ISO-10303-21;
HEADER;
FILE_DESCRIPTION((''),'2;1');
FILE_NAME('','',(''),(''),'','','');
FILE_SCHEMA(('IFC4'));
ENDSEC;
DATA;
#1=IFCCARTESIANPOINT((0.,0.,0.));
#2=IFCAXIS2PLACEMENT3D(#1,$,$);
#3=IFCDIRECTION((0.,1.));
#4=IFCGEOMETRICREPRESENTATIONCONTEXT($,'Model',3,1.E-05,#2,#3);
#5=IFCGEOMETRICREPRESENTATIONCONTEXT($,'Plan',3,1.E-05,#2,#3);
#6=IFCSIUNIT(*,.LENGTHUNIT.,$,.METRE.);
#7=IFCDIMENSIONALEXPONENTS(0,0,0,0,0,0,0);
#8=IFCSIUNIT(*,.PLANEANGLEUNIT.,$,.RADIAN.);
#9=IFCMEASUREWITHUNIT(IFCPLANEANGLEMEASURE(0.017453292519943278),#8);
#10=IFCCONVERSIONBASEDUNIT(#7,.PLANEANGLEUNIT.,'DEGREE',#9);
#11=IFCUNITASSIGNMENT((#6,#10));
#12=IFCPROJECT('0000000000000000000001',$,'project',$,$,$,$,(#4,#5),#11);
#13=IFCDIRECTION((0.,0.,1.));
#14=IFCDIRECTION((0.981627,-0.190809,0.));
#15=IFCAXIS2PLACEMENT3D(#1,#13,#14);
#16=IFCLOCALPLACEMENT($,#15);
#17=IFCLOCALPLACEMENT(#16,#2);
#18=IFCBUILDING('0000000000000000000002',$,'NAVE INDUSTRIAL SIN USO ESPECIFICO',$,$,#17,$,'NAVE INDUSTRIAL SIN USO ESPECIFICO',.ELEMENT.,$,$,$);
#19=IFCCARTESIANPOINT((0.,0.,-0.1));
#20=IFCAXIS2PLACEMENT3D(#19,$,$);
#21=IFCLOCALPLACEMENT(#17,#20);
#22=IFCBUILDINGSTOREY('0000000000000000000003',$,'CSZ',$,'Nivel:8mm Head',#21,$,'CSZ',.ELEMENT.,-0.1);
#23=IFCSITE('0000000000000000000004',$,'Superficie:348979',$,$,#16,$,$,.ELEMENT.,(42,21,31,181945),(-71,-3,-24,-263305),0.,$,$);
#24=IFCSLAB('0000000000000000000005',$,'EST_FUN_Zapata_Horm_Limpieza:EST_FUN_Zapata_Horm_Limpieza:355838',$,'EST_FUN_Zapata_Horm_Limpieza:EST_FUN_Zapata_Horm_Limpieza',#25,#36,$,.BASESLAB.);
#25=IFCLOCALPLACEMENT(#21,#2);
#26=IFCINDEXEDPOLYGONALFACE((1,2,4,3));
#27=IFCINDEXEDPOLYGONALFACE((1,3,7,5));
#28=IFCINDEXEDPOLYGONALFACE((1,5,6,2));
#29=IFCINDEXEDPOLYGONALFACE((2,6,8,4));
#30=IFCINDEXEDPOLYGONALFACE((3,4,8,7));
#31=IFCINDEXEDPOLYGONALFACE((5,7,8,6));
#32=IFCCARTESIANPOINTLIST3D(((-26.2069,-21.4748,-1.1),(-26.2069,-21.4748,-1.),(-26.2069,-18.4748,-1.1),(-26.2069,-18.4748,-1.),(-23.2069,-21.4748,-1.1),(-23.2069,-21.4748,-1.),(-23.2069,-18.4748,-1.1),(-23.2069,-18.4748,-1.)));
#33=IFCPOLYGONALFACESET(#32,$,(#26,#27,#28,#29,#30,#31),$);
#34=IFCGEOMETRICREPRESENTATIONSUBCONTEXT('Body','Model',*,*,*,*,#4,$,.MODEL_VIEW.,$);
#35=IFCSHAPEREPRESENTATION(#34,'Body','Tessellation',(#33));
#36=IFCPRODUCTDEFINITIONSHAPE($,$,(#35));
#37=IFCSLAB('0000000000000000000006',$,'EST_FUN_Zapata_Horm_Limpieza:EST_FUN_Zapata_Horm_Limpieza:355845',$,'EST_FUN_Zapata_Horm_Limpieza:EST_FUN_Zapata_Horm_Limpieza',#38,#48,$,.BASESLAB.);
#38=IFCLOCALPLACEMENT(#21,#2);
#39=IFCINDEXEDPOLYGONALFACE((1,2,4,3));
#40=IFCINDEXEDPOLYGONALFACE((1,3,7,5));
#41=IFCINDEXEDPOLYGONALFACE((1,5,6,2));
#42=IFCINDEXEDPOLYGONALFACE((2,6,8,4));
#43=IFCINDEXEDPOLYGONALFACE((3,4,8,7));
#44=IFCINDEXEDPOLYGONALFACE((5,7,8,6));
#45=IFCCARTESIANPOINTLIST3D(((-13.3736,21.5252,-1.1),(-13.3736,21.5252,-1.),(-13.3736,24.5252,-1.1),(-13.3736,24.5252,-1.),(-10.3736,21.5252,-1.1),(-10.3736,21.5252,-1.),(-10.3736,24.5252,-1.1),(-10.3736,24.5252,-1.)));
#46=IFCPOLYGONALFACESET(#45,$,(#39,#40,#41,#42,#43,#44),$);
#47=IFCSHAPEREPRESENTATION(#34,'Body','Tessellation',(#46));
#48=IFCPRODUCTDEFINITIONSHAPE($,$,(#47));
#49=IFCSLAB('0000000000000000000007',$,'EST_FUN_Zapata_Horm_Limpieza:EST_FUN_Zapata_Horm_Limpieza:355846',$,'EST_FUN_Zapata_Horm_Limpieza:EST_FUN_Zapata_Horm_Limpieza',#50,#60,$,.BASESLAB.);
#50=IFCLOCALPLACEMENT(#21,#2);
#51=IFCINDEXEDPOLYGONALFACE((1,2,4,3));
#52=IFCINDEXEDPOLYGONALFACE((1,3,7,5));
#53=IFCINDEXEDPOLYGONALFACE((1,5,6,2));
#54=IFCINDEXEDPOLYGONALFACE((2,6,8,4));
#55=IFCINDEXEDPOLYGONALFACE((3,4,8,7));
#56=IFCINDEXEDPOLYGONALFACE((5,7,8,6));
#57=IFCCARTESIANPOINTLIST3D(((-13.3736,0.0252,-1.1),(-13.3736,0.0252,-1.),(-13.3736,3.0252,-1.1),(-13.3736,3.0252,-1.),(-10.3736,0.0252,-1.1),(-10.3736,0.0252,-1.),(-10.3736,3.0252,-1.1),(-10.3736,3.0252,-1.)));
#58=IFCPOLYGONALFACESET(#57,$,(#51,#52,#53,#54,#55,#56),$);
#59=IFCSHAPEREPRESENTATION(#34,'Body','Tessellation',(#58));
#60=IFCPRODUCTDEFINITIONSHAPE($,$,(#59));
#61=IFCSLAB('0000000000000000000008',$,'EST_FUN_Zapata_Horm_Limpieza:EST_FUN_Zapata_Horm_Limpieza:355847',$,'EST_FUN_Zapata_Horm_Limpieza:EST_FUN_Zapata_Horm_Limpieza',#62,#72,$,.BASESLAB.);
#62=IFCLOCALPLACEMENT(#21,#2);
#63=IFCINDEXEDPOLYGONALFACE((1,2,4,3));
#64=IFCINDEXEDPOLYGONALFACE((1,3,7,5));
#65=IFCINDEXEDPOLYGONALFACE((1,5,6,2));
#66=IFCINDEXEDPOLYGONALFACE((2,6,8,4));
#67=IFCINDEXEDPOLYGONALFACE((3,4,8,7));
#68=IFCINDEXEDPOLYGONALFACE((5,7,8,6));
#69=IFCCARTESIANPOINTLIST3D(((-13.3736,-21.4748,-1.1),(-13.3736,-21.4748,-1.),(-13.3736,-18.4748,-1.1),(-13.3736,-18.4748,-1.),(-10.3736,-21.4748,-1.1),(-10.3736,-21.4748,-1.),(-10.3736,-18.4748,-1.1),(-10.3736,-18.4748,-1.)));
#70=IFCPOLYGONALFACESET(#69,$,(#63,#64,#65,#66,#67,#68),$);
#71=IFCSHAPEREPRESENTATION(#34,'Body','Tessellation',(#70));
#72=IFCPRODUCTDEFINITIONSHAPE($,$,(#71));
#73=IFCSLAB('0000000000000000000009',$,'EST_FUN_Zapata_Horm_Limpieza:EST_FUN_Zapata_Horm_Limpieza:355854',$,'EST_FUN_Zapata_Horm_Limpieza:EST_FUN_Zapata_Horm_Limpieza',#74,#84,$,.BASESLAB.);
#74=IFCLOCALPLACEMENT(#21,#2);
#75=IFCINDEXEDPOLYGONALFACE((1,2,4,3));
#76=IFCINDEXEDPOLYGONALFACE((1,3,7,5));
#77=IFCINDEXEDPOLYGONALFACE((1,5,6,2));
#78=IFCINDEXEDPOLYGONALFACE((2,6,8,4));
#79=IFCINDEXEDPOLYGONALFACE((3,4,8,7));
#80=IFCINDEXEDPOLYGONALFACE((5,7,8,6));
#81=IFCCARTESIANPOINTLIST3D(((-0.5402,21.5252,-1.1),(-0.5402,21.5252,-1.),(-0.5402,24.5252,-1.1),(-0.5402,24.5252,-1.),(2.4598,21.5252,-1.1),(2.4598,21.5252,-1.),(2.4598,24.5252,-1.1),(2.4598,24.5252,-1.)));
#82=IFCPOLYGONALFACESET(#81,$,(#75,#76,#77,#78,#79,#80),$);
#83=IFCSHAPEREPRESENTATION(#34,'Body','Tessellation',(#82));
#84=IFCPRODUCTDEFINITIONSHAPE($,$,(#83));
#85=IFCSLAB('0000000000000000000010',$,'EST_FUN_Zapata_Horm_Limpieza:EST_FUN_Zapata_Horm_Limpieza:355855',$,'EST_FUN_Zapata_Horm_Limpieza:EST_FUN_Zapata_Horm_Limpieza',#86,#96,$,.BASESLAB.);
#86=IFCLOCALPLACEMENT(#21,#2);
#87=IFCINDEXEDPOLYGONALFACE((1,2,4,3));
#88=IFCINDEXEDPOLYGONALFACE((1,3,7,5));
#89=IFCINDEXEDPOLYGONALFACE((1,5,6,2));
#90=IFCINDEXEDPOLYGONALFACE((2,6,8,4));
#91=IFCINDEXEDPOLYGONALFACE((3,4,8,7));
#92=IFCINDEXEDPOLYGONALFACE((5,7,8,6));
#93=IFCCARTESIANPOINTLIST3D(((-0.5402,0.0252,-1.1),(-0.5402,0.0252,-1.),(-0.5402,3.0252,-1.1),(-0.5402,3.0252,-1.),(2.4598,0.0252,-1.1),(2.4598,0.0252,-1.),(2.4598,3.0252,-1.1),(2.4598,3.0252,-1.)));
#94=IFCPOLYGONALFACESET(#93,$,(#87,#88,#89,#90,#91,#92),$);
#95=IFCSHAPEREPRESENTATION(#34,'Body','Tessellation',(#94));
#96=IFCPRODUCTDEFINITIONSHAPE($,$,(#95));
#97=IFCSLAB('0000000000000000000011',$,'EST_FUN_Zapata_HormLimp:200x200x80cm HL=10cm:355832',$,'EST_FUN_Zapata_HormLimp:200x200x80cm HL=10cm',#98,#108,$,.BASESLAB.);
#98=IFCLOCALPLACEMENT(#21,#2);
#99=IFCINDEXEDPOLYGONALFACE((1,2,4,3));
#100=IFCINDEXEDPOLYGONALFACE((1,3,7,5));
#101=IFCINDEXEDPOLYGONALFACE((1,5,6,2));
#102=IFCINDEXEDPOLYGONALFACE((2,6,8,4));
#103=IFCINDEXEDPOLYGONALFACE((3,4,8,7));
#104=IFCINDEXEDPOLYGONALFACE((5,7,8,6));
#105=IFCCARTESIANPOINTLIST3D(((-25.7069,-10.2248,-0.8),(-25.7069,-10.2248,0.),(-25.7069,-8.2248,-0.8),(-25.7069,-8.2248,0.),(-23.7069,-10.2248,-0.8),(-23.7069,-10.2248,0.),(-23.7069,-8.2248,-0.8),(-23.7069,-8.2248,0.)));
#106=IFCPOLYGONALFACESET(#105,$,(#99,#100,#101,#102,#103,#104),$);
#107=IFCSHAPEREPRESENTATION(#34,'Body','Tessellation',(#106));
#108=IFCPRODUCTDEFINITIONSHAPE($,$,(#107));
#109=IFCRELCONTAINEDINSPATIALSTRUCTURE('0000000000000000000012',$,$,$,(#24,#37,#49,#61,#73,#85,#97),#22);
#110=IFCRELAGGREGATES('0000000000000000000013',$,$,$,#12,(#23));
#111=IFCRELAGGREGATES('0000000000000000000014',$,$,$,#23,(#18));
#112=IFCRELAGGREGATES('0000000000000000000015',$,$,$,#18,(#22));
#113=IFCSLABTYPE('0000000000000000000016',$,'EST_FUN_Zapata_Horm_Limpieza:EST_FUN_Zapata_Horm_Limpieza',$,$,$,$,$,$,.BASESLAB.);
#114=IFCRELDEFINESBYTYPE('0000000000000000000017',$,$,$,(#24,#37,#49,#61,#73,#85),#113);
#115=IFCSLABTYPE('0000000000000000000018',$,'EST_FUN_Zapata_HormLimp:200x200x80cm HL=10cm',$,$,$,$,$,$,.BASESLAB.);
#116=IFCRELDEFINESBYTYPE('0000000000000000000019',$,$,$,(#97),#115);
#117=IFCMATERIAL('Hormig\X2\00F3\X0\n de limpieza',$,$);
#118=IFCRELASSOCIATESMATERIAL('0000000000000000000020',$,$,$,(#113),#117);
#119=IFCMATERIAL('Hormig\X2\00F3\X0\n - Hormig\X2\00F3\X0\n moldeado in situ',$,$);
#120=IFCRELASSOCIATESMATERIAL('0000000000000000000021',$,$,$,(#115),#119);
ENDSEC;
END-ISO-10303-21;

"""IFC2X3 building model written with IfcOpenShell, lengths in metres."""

from ifc_helpers import new_model, entity, si_unit, converted_unit, direction, frame, frame_2d, origin, origin_2d_with_axis, place, context, subcontext, project, spatial, rectangle, extrude, material, type_object, element, save


model = new_model("IFC2X3")

# Units and contexts
model_context = context("Model", 3, precision=1e-05, world=origin(), true_north=direction((0.0, 1.0)))
plan_context = context("Plan", 3, precision=1e-05, world=origin(), true_north=direction((0.0, 1.0)))
body_context = subcontext(model_context, "Body", "Model", "MODEL_VIEW")
ifc_project = project(units=[si_unit("LENGTHUNIT", "METRE"), converted_unit("PLANEANGLEUNIT", "DEGREE", entity("IfcPlaneAngleMeasure", 0.017453292519943278), si_unit("PLANEANGLEUNIT", "RADIAN"), dimensions=[0, 0, 0, 0, 0, 0, 0])], contexts=[model_context, plan_context])

# Site, building, storey
site_placement = place(None, frame((0.0, 0.0, 0.0), z_axis=(0.0, 0.0, 1.0), x_axis=(0.981627, -0.190809, 0.0)))
site = spatial("IfcSite", under=ifc_project, at=site_placement, Name="Superficie:348979", CompositionType="ELEMENT", RefLatitude=(42, 21, 31, 181945), RefLongitude=(-71, -3, -24, -263305), RefElevation=0.0)
building_placement = place(site_placement, origin())
building = spatial("IfcBuilding", under=site, at=building_placement, Name="NAVE INDUSTRIAL SIN USO ESPECIFICO", LongName="NAVE INDUSTRIAL SIN USO ESPECIFICO", CompositionType="ELEMENT")
storey_placement = place(building_placement, frame((0.0, 0.0, -0.1)))
storey = spatial("IfcBuildingStorey", under=building, at=storey_placement, Name="CSZ", ObjectType="Nivel:8mm Head", LongName="CSZ", CompositionType="ELEMENT", Elevation=-0.1)

# Slabs
ifc_material_1 = material(Name="Hormigón - Hormigón moldeado in situ")
ifc_material_2 = material(Name="Hormigón de limpieza")
slab_type_1 = type_object("IfcSlabType", Name="EST_FUN_Zapata_Horm_Limpieza:EST_FUN_Zapata_Horm_Limpieza", PredefinedType="BASESLAB", material=ifc_material_2)
slab_1_placement = place(storey_placement, frame((0.0, 0.0, -1.0)))
element("IfcSlab", 1, at=slab_1_placement, inside=storey, type_object=slab_type_1, Name="EST_FUN_Zapata_Horm_Limpieza:EST_FUN_Zapata_Horm_Limpieza:355838", ObjectType="EST_FUN_Zapata_Horm_Limpieza:EST_FUN_Zapata_Horm_Limpieza", PredefinedType="BASESLAB", context=body_context, shape_type="SweptSolid", body=[
    extrude(rectangle(XDim=3.0, YDim=3.0, at=frame_2d((0.0, 0.0), x_axis=(1.0, 0.0))), frame((-24.7069, -19.9748, -0.1)), (0.0, 0.0, 1.0), 0.1),
])
slab_2_placement = place(storey_placement, frame((0.0, 0.0, -1.0)))
element("IfcSlab", 2, at=slab_2_placement, inside=storey, type_object=slab_type_1, Name="EST_FUN_Zapata_Horm_Limpieza:EST_FUN_Zapata_Horm_Limpieza:355845", ObjectType="EST_FUN_Zapata_Horm_Limpieza:EST_FUN_Zapata_Horm_Limpieza", PredefinedType="BASESLAB", context=body_context, shape_type="SweptSolid", body=[
    extrude(rectangle(XDim=3.0, YDim=3.0, at=origin_2d_with_axis()), frame((-11.8736, 23.0252, -0.1)), (0.0, 0.0, 1.0), 0.1),
])
slab_3_placement = place(storey_placement, frame((0.0, 0.0, -1.0)))
element("IfcSlab", 3, at=slab_3_placement, inside=storey, type_object=slab_type_1, Name="EST_FUN_Zapata_Horm_Limpieza:EST_FUN_Zapata_Horm_Limpieza:355846", ObjectType="EST_FUN_Zapata_Horm_Limpieza:EST_FUN_Zapata_Horm_Limpieza", PredefinedType="BASESLAB", context=body_context, shape_type="SweptSolid", body=[
    extrude(rectangle(XDim=3.0, YDim=3.0, at=origin_2d_with_axis()), frame((-11.8736, 1.5252, -0.1)), (0.0, 0.0, 1.0), 0.1),
])
slab_4_placement = place(storey_placement, frame((0.0, 0.0, -1.0)))
element("IfcSlab", 4, at=slab_4_placement, inside=storey, type_object=slab_type_1, Name="EST_FUN_Zapata_Horm_Limpieza:EST_FUN_Zapata_Horm_Limpieza:355847", ObjectType="EST_FUN_Zapata_Horm_Limpieza:EST_FUN_Zapata_Horm_Limpieza", PredefinedType="BASESLAB", context=body_context, shape_type="SweptSolid", body=[
    extrude(rectangle(XDim=3.0, YDim=3.0, at=frame_2d((0.0, 0.0), x_axis=(1.0, 0.0))), frame((-11.8736, -19.9748, -0.1)), (0.0, 0.0, 1.0), 0.1),
])
slab_5_placement = place(storey_placement, frame((0.0, 0.0, -1.0)))
element("IfcSlab", 5, at=slab_5_placement, inside=storey, type_object=slab_type_1, Name="EST_FUN_Zapata_Horm_Limpieza:EST_FUN_Zapata_Horm_Limpieza:355854", ObjectType="EST_FUN_Zapata_Horm_Limpieza:EST_FUN_Zapata_Horm_Limpieza", PredefinedType="BASESLAB", context=body_context, shape_type="SweptSolid", body=[
    extrude(rectangle(XDim=3.0, YDim=3.0, at=origin_2d_with_axis()), frame((0.9598, 23.0252, -0.1)), (0.0, 0.0, 1.0), 0.1),
])
slab_6_placement = place(storey_placement, frame((0.0, 0.0, -1.0)))
element("IfcSlab", 6, at=slab_6_placement, inside=storey, type_object=slab_type_1, Name="EST_FUN_Zapata_Horm_Limpieza:EST_FUN_Zapata_Horm_Limpieza:355855", ObjectType="EST_FUN_Zapata_Horm_Limpieza:EST_FUN_Zapata_Horm_Limpieza", PredefinedType="BASESLAB", context=body_context, shape_type="SweptSolid", body=[
    extrude(rectangle(XDim=3.0, YDim=3.0, at=origin_2d_with_axis()), frame((0.9598, 1.5252, -0.1)), (0.0, 0.0, 1.0), 0.1),
])
slab_type_2 = type_object("IfcSlabType", Name="EST_FUN_Zapata_HormLimp:200x200x80cm HL=10cm", PredefinedType="BASESLAB", material=ifc_material_1)
slab_7_placement = place(storey_placement, origin())
element("IfcSlab", 7, at=slab_7_placement, inside=storey, type_object=slab_type_2, Name="EST_FUN_Zapata_HormLimp:200x200x80cm HL=10cm:355832", ObjectType="EST_FUN_Zapata_HormLimp:200x200x80cm HL=10cm", PredefinedType="BASESLAB", context=body_context, shape_type="SweptSolid", body=[
    extrude(rectangle(XDim=2.0, YDim=2.0, at=frame_2d((0.0, 0.0), x_axis=(1.0, 0.0))), frame((-24.7069, -9.2248, -0.8)), (0.0, 0.0, 1.0), 0.8),
])

save(model, "model.ifc")
